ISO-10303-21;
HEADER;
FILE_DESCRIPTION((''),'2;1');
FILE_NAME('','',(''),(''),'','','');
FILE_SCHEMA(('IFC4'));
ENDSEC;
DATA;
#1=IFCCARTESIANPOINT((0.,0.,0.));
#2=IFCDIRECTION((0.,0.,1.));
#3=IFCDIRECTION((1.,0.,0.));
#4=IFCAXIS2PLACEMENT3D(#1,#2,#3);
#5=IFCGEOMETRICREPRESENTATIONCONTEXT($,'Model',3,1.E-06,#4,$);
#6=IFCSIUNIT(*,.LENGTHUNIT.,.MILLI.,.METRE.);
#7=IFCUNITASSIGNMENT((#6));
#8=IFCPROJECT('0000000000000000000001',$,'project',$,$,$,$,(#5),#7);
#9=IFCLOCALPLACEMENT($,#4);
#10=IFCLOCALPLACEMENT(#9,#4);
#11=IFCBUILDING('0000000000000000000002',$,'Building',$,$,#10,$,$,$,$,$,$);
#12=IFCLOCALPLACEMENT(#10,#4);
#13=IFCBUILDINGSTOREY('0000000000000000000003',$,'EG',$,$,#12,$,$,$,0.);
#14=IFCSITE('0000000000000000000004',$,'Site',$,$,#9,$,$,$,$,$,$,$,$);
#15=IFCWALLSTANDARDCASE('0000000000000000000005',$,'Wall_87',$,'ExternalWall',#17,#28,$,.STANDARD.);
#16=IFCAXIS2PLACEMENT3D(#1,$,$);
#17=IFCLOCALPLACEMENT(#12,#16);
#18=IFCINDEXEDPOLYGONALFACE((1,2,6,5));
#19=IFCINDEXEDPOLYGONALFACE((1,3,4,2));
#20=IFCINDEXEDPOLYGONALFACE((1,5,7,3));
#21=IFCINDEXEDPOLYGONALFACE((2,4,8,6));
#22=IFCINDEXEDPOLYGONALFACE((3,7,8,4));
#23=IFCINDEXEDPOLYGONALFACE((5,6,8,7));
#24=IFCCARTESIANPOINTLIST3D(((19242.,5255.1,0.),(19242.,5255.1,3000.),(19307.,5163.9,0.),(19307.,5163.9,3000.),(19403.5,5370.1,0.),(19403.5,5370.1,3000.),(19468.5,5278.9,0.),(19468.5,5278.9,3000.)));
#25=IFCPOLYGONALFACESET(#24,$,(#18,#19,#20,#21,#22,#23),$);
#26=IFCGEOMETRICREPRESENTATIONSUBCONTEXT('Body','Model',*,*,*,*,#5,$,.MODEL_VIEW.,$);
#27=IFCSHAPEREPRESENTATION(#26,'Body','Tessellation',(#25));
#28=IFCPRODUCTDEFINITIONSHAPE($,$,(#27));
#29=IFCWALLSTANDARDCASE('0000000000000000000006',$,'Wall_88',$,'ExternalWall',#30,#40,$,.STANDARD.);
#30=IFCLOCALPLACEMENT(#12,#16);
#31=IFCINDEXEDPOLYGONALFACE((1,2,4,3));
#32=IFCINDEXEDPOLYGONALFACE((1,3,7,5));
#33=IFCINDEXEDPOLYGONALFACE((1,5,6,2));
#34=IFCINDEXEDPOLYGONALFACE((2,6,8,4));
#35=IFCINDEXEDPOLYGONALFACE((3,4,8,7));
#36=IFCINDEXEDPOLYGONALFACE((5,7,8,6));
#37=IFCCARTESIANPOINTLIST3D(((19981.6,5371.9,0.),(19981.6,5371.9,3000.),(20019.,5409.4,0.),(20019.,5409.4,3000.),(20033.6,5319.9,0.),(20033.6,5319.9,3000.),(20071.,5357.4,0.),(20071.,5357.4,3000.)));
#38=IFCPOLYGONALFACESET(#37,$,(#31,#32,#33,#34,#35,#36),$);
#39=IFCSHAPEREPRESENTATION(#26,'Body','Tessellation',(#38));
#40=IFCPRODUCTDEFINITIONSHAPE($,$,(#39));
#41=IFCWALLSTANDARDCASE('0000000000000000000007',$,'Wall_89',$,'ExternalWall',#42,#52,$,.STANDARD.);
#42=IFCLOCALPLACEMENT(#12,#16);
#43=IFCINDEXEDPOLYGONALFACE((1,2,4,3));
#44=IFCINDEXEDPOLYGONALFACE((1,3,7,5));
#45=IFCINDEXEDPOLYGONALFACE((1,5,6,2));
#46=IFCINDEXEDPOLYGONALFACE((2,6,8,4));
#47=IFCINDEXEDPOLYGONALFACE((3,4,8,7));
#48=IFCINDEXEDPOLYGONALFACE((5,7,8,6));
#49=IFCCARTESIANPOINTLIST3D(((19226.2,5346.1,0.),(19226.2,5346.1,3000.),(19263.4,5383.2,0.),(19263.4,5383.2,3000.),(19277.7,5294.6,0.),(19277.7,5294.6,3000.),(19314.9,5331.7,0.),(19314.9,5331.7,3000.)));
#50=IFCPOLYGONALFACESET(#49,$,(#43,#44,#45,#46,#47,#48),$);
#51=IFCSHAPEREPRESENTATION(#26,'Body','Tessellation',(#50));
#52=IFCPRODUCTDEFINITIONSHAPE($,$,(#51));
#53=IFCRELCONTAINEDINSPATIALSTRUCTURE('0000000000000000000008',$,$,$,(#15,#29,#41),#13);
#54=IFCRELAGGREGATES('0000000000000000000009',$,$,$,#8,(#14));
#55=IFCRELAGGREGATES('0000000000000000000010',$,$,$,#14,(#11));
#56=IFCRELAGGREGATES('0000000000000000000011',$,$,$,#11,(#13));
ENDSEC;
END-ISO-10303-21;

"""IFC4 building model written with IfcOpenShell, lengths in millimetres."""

from ifc_helpers import new_model, si_unit, frame, origin_with_axes, place, context, subcontext, project, spatial, rectangle, extrude, element, save


model = new_model("IFC4")

# Units and contexts
model_context = context("Model", 3, precision=1e-06, world=origin_with_axes())
body_context = subcontext(model_context, "Body", "Model", "MODEL_VIEW")
ifc_project = project(units=[si_unit("LENGTHUNIT", "METRE", prefix="MILLI")], contexts=[model_context])

# Site, building, storey
site_placement = place(None, origin_with_axes())
site = spatial("IfcSite", under=ifc_project, at=site_placement, Name="Site")
building_placement = place(site_placement, origin_with_axes())
building = spatial("IfcBuilding", under=site, at=building_placement, Name="Building")
storey_placement = place(building_placement, origin_with_axes())
storey = spatial("IfcBuildingStorey", under=building, at=storey_placement, Name="EG", Elevation=0.0)

# Walls
wall_1_placement = place(storey_placement, origin_with_axes())
element("IfcWallStandardCase", 1, at=wall_1_placement, inside=storey, Name="Wall_87", ObjectType="ExternalWall", PredefinedType="STANDARD", context=body_context, shape_type="SweptSolid", body=[
    extrude(rectangle(XDim=112.0, YDim=198.3), frame((19355.3, 5267.0, 0.0), z_axis=(0.0, 0.0, 1.0), x_axis=(-0.580182, 0.814487, 0.0)), (0.0, 0.0, 1.0), 3000.0),
])
wall_2_placement = place(storey_placement, origin_with_axes())
element("IfcWallStandardCase", 2, at=wall_2_placement, inside=storey, Name="Wall_88", ObjectType="ExternalWall", PredefinedType="STANDARD", context=body_context, shape_type="SweptSolid", body=[
    extrude(rectangle(XDim=73.5, YDim=53.0), frame((20026.3, 5364.6, 0.0), z_axis=(0.0, 0.0, 1.0), x_axis=(0.707107, -0.707107, 0.0)), (0.0, 0.0, 1.0), 3000.0),
])
wall_3_placement = place(storey_placement, origin_with_axes())
element("IfcWallStandardCase", 3, at=wall_3_placement, inside=storey, Name="Wall_89", ObjectType="ExternalWall", PredefinedType="STANDARD", context=body_context, shape_type="SweptSolid", body=[
    extrude(rectangle(XDim=72.8, YDim=52.5), frame((19270.5, 5338.9, 0.0), z_axis=(0.0, 0.0, 1.0), x_axis=(0.707107, -0.707107, 0.0)), (0.0, 0.0, 1.0), 3000.0),
])

save(model, "model.ifc")
